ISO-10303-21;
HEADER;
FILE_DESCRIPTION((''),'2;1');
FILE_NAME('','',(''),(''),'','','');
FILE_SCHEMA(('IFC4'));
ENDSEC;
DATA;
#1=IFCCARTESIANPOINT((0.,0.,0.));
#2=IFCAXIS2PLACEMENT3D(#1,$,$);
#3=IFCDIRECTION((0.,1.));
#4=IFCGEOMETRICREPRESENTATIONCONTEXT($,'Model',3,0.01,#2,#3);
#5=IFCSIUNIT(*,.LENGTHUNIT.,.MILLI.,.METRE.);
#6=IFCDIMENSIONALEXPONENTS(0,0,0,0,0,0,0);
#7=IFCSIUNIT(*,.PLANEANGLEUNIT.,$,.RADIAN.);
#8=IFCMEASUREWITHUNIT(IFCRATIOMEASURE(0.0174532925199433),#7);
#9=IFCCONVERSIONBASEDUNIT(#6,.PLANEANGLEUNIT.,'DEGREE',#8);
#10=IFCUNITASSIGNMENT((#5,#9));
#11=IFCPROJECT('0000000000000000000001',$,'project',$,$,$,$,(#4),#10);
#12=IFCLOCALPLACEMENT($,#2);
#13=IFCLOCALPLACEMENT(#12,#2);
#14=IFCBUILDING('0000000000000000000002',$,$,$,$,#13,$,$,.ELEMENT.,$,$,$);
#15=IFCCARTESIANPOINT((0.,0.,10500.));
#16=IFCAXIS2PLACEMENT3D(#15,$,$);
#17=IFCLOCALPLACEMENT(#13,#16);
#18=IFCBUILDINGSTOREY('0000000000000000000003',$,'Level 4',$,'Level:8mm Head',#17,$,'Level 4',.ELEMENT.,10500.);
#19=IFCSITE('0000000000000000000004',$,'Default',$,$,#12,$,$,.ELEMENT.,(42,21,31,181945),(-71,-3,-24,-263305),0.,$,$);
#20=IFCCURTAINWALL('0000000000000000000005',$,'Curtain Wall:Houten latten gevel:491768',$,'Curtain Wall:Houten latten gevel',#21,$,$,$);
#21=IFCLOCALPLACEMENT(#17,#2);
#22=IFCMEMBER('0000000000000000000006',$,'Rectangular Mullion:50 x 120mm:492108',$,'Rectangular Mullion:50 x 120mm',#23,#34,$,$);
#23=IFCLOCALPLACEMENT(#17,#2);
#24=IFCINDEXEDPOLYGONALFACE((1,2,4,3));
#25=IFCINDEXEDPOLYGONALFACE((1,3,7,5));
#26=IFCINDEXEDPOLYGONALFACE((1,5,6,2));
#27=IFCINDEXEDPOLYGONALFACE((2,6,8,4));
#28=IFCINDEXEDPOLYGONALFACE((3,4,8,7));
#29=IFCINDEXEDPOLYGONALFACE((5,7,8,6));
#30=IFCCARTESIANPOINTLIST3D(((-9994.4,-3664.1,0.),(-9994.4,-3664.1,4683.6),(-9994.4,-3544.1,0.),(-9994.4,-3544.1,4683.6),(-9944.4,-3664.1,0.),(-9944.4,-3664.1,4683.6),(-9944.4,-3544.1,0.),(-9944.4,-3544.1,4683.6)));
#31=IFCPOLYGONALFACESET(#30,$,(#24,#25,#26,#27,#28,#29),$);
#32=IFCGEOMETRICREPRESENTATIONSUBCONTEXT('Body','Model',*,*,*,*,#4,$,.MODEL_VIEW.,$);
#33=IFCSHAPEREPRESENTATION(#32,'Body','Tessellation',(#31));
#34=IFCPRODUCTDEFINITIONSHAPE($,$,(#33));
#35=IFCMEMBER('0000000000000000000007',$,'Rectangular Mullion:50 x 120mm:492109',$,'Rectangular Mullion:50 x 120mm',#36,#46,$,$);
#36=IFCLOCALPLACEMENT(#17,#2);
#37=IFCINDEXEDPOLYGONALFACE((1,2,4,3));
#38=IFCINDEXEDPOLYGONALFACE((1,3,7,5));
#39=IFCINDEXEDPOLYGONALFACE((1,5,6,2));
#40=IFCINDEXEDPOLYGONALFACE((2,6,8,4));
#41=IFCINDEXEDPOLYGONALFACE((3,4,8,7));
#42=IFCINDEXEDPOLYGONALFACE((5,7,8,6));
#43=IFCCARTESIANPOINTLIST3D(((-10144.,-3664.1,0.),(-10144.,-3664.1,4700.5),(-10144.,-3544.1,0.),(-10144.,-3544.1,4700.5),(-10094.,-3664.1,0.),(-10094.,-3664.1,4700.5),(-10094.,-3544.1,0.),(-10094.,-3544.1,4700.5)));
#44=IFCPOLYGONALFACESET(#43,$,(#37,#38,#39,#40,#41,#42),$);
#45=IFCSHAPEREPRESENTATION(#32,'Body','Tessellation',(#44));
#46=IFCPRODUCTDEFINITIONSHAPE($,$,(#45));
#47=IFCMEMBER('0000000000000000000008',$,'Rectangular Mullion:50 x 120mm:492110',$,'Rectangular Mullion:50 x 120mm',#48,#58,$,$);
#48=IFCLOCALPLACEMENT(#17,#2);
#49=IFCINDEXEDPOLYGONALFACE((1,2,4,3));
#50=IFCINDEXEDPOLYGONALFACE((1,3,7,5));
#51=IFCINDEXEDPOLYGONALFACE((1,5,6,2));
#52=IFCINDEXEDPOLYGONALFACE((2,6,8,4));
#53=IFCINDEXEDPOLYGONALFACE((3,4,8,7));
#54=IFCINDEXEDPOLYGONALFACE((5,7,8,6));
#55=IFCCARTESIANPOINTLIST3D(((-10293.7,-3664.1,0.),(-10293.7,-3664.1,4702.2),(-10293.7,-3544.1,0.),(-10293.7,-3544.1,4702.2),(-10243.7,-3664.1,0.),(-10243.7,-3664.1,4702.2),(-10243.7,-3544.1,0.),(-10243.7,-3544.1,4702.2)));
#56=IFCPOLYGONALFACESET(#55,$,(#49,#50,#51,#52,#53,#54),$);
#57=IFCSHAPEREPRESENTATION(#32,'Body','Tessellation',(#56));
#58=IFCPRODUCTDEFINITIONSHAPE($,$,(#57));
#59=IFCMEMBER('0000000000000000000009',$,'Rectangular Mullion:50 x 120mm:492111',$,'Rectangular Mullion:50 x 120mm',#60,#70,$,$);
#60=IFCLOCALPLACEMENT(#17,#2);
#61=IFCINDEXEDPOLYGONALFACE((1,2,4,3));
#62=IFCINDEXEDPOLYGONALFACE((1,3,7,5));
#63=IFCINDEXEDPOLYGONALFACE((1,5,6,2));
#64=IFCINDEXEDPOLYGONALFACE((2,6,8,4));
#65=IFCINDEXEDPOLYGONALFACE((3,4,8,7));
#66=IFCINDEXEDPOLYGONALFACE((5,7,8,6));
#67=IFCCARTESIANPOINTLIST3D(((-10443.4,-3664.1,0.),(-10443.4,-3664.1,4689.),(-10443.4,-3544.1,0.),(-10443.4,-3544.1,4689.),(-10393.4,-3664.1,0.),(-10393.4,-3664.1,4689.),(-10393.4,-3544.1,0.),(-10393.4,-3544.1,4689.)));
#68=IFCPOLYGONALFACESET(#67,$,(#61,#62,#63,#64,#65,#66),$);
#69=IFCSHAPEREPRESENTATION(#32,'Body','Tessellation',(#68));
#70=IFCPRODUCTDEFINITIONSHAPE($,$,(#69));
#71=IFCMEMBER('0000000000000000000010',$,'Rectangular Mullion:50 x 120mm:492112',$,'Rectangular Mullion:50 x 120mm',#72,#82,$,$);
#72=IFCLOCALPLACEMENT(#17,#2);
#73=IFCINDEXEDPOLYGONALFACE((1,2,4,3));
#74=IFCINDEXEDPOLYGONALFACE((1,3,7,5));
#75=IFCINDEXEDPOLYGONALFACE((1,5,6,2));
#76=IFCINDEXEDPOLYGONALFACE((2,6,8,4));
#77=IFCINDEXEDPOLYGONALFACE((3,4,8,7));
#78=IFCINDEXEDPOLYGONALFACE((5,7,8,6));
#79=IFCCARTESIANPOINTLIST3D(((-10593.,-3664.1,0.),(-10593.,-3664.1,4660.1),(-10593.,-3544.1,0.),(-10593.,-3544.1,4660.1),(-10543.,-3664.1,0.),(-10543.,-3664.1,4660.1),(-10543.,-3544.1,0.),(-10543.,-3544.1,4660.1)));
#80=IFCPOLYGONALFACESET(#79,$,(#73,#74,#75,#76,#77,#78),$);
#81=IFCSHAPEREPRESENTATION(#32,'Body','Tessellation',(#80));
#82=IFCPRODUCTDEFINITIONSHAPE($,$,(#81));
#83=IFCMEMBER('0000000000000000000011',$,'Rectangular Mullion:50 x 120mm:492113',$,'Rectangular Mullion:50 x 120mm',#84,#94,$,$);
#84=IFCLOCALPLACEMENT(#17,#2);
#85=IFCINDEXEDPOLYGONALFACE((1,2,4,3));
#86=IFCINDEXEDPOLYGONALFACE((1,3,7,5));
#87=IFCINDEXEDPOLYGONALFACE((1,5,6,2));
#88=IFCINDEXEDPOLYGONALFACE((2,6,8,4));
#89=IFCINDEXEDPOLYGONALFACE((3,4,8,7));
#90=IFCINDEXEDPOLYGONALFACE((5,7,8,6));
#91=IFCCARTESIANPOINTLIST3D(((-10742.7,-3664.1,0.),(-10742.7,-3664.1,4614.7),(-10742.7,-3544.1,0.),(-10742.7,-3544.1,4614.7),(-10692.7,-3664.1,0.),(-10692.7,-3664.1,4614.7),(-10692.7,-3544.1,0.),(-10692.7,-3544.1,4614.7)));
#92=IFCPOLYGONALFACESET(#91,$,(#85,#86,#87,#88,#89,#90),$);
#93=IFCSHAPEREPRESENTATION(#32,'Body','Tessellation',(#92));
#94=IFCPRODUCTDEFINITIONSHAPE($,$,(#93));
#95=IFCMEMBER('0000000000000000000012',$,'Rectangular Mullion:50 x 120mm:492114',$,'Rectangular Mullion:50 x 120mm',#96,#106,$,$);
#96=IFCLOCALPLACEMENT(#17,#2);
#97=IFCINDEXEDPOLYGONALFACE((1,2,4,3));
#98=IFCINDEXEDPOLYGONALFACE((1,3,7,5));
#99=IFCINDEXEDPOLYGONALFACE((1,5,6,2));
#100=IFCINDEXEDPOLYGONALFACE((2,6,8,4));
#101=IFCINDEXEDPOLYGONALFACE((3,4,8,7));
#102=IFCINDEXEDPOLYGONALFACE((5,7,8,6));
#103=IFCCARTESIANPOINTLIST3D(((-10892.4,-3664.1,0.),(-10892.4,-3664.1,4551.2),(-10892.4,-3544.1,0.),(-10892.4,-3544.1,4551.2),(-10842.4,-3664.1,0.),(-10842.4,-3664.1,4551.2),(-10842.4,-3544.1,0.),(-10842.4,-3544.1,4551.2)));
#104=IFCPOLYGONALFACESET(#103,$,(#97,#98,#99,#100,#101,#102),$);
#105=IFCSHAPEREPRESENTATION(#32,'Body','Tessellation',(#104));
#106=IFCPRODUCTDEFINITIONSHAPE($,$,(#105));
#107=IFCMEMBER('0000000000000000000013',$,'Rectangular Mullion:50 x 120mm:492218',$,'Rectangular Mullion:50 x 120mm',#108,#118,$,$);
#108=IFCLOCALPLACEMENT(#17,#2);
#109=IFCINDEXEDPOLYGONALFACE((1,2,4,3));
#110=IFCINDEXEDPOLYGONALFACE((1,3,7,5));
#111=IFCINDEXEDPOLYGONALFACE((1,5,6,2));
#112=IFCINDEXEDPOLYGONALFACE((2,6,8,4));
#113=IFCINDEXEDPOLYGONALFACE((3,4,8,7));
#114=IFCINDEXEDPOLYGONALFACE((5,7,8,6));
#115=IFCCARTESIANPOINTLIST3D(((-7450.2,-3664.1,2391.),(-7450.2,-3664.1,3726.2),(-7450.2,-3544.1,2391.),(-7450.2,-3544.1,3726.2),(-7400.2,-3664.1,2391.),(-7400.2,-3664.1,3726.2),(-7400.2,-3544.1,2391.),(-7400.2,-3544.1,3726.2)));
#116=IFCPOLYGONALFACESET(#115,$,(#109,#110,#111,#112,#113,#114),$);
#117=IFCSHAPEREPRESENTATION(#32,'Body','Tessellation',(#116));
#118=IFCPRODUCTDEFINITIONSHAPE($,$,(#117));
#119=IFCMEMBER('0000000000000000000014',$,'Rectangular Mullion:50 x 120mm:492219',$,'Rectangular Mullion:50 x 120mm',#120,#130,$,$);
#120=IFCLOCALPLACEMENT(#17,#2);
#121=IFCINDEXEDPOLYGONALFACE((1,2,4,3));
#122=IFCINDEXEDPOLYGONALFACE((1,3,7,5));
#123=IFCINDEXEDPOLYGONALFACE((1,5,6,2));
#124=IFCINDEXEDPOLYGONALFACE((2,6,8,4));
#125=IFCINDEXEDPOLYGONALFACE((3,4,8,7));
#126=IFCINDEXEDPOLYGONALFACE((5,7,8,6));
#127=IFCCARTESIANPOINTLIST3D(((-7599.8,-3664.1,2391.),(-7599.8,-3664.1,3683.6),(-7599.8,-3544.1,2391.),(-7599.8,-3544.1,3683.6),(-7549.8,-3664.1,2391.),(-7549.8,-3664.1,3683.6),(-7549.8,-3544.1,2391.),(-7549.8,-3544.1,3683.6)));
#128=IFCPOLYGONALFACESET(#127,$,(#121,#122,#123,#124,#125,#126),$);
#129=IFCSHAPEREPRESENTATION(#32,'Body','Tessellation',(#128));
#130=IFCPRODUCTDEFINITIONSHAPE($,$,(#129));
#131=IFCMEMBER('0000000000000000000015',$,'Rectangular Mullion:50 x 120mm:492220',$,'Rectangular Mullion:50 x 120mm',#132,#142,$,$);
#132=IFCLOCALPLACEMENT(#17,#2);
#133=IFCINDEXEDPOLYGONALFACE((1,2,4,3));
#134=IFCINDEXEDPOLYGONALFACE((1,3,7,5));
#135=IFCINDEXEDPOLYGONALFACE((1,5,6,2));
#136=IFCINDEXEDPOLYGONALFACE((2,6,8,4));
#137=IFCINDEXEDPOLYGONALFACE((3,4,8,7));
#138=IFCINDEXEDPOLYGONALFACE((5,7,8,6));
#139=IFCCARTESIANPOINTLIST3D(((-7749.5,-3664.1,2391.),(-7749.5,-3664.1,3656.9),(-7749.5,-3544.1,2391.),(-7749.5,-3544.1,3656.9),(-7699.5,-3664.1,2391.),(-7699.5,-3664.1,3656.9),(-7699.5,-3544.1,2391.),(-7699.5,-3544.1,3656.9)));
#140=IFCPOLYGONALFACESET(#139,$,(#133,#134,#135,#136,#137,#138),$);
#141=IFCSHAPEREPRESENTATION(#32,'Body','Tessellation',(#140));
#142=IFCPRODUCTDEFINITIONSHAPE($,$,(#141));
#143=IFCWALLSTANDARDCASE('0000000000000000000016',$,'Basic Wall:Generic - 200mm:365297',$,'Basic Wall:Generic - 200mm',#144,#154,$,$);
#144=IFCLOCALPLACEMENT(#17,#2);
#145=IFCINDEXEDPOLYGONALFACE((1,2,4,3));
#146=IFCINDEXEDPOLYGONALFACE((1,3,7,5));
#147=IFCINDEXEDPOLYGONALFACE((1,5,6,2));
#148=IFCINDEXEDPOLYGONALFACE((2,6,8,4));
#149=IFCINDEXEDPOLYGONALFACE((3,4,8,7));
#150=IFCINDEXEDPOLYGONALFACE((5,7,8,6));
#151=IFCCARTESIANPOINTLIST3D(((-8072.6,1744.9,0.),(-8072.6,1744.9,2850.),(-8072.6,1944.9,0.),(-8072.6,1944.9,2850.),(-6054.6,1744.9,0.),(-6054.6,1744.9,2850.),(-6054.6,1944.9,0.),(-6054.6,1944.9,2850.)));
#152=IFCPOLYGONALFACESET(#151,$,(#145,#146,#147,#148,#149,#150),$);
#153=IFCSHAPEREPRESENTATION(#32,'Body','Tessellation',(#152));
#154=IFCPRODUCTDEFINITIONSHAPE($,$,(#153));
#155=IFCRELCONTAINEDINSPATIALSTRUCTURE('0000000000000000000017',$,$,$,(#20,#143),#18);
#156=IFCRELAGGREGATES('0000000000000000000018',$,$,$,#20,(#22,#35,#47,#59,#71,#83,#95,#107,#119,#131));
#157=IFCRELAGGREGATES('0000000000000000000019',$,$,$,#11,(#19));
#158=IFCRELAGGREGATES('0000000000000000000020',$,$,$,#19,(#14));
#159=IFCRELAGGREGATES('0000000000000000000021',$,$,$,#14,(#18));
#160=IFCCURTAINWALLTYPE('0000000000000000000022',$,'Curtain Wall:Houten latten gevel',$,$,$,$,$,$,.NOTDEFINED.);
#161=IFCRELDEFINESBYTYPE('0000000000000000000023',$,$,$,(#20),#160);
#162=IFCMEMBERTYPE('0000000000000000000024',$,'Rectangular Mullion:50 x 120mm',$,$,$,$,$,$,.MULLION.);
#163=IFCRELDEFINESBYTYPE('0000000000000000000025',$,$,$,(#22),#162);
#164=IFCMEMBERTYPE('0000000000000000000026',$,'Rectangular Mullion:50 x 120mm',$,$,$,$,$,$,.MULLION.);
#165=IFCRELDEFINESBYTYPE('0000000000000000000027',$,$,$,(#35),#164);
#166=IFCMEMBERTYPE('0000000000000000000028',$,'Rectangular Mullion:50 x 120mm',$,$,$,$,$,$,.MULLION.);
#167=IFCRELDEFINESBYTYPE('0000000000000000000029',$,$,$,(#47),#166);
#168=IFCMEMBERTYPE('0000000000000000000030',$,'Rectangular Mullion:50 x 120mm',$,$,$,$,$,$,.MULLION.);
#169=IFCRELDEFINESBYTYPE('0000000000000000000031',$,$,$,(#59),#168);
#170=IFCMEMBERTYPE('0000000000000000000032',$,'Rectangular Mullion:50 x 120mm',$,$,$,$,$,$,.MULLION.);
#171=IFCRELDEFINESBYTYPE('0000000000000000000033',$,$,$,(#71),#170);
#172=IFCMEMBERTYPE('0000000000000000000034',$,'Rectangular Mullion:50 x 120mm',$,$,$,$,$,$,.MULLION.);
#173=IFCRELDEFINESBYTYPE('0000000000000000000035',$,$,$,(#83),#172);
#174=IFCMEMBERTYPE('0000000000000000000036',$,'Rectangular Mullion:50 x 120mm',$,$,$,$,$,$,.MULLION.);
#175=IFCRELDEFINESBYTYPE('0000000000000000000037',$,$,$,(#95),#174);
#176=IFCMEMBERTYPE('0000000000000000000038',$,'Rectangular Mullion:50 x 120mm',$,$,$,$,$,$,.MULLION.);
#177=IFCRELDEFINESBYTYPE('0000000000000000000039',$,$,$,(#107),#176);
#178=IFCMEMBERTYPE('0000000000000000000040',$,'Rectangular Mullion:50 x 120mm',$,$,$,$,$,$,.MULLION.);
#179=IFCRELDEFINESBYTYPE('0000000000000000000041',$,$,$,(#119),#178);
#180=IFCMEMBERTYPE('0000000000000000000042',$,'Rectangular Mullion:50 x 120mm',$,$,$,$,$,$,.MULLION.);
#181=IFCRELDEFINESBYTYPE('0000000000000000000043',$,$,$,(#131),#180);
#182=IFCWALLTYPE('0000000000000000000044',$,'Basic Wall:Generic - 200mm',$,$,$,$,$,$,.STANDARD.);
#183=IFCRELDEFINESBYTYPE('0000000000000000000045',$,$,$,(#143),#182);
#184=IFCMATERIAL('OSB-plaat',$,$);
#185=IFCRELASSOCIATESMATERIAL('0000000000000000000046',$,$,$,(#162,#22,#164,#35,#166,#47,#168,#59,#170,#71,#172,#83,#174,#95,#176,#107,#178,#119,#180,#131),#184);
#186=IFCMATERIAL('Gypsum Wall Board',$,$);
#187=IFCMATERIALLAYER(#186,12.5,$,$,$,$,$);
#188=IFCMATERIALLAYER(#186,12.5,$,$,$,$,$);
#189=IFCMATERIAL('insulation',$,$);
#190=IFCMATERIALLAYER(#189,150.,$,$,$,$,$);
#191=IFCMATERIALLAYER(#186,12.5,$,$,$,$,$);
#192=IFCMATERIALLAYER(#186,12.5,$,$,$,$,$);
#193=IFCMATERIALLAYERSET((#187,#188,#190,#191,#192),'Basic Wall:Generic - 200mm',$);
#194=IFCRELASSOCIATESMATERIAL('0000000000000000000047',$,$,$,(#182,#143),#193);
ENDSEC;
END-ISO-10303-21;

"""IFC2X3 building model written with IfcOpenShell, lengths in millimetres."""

from ifc_helpers import new_model, entity, si_unit, converted_unit, direction, frame, frame_2d, origin, origin_2d_with_axis, place, context, subcontext, project, spatial, rectangle, extrude, source, transform, mapped, material, layer, layer_set, layer_usage, type_object, type_shapes, element, aggregate, save


model = new_model("IFC2X3")

# Units and contexts
model_context = context("Model", 3, precision=0.01, world=origin(), true_north=direction((0.0, 1.0)))
body_context = subcontext(model_context, "Body", "Model", "MODEL_VIEW")
ifc_project = project(units=[si_unit("LENGTHUNIT", "METRE", prefix="MILLI"), converted_unit("PLANEANGLEUNIT", "DEGREE", entity("IfcRatioMeasure", 0.0174532925199433), si_unit("PLANEANGLEUNIT", "RADIAN"), dimensions=[0, 0, 0, 0, 0, 0, 0])], contexts=[model_context])

# Site, building, storey
site_placement = place(None, frame((0.0, 0.0, 0.0)))
site = spatial("IfcSite", under=ifc_project, at=site_placement, Name="Default", CompositionType="ELEMENT", RefLatitude=(42, 21, 31, 181945), RefLongitude=(-71, -3, -24, -263305), RefElevation=0.0)
building_placement = place(site_placement, origin())
building = spatial("IfcBuilding", under=site, at=building_placement, CompositionType="ELEMENT")
storey_placement = place(building_placement, frame((0.0, 0.0, 10500.0)))
storey = spatial("IfcBuildingStorey", under=building, at=storey_placement, Name="Level 4", ObjectType="Level:8mm Head", LongName="Level 4", CompositionType="ELEMENT", Elevation=10500.0)

# Curtain wall, members
curtain_wall_type_1 = type_object("IfcCurtainWallType", Name="Curtain Wall:Houten latten gevel", PredefinedType="NOTDEFINED")
curtain_wall_1_placement = place(storey_placement, frame((0.0, 0.0, -10500.0)))
curtain_wall_1 = element("IfcCurtainWall", 1, at=curtain_wall_1_placement, inside=storey, type_object=curtain_wall_type_1, Name="Curtain Wall:Houten latten gevel:491768", ObjectType="Curtain Wall:Houten latten gevel")
ifc_material_1 = material(Name="OSB-plaat")
placement = place(building_placement, frame((0.0, 0.0, 7500.0)))
member_type_1 = type_object("IfcMemberType", Name="Rectangular Mullion:50 x 120mm", PredefinedType="MULLION", material=ifc_material_1)
shared_shape_1 = source(origin(), body_context, "Body", "SweptSolid", [
    extrude(rectangle(XDim=120.0, YDim=50.0, at=origin_2d_with_axis()), frame((0.0, 0.0, -4683.6), z_axis=(0.0, 0.0, 1.0), x_axis=(0.0, -1.0, 0.0)), (0.0, 0.0, 1.0), 4683.6),
])
type_shapes(member_type_1, [shared_shape_1])
member_1_placement = place(placement, frame((-9969.4, -3604.1, 3000.0), z_axis=(0.0, 0.0, -1.0), x_axis=(-1.0, 0.0, 0.0)))
member_1 = element("IfcMember", 2, at=member_1_placement, type_object=member_type_1, material=ifc_material_1, Name="Rectangular Mullion:50 x 120mm:492108", ObjectType="Rectangular Mullion:50 x 120mm", context=body_context, shape_type="MappedRepresentation", body=[
    mapped(shared_shape_1, transform((0.0, 0.0, 0.0), scale=1.0)),
])
member_type_2 = type_object("IfcMemberType", Name="Rectangular Mullion:50 x 120mm", PredefinedType="MULLION", material=ifc_material_1)
shared_shape_2 = source(origin(), body_context, "Body", "SweptSolid", [
    extrude(rectangle(XDim=120.0, YDim=50.0, at=origin_2d_with_axis()), frame((0.0, 0.0, -4700.5), z_axis=(0.0, 0.0, 1.0), x_axis=(0.0, -1.0, 0.0)), (0.0, 0.0, 1.0), 4700.5),
])
type_shapes(member_type_2, [shared_shape_2])
member_2_placement = place(placement, frame((-10119.0, -3604.1, 3000.0), z_axis=(0.0, 0.0, -1.0), x_axis=(-1.0, 0.0, 0.0)))
member_2 = element("IfcMember", 3, at=member_2_placement, type_object=member_type_2, material=ifc_material_1, Name="Rectangular Mullion:50 x 120mm:492109", ObjectType="Rectangular Mullion:50 x 120mm", context=body_context, shape_type="MappedRepresentation", body=[
    mapped(shared_shape_2, transform((0.0, 0.0, 0.0), scale=1.0)),
])
member_type_3 = type_object("IfcMemberType", Name="Rectangular Mullion:50 x 120mm", PredefinedType="MULLION", material=ifc_material_1)
shared_shape_3 = source(origin(), body_context, "Body", "SweptSolid", [
    extrude(rectangle(XDim=120.0, YDim=50.0, at=origin_2d_with_axis()), frame((0.0, 0.0, -4702.2), z_axis=(0.0, 0.0, 1.0), x_axis=(0.0, -1.0, 0.0)), (0.0, 0.0, 1.0), 4702.2),
])
type_shapes(member_type_3, [shared_shape_3])
member_3_placement = place(placement, frame((-10268.7, -3604.1, 3000.0), z_axis=(0.0, 0.0, -1.0), x_axis=(-1.0, 0.0, 0.0)))
member_3 = element("IfcMember", 4, at=member_3_placement, type_object=member_type_3, material=ifc_material_1, Name="Rectangular Mullion:50 x 120mm:492110", ObjectType="Rectangular Mullion:50 x 120mm", context=body_context, shape_type="MappedRepresentation", body=[
    mapped(shared_shape_3, transform((0.0, 0.0, 0.0), scale=1.0)),
])
member_type_4 = type_object("IfcMemberType", Name="Rectangular Mullion:50 x 120mm", PredefinedType="MULLION", material=ifc_material_1)
shared_shape_4 = source(origin(), body_context, "Body", "SweptSolid", [
    extrude(rectangle(XDim=120.0, YDim=50.0, at=origin_2d_with_axis()), frame((0.0, 0.0, -4689.0), z_axis=(0.0, 0.0, 1.0), x_axis=(0.0, -1.0, 0.0)), (0.0, 0.0, 1.0), 4689.0),
])
type_shapes(member_type_4, [shared_shape_4])
member_4_placement = place(placement, frame((-10418.4, -3604.1, 3000.0), z_axis=(0.0, 0.0, -1.0), x_axis=(-1.0, 0.0, 0.0)))
member_4 = element("IfcMember", 5, at=member_4_placement, type_object=member_type_4, material=ifc_material_1, Name="Rectangular Mullion:50 x 120mm:492111", ObjectType="Rectangular Mullion:50 x 120mm", context=body_context, shape_type="MappedRepresentation", body=[
    mapped(shared_shape_4, transform((0.0, 0.0, 0.0), scale=1.0)),
])
member_type_5 = type_object("IfcMemberType", Name="Rectangular Mullion:50 x 120mm", PredefinedType="MULLION", material=ifc_material_1)
shared_shape_5 = source(origin(), body_context, "Body", "SweptSolid", [
    extrude(rectangle(XDim=120.0, YDim=50.0, at=origin_2d_with_axis()), frame((0.0, 0.0, -4660.1), z_axis=(0.0, 0.0, 1.0), x_axis=(0.0, -1.0, 0.0)), (0.0, 0.0, 1.0), 4660.1),
])
type_shapes(member_type_5, [shared_shape_5])
member_5_placement = place(placement, frame((-10568.0, -3604.1, 3000.0), z_axis=(0.0, 0.0, -1.0), x_axis=(-1.0, 0.0, 0.0)))
member_5 = element("IfcMember", 6, at=member_5_placement, type_object=member_type_5, material=ifc_material_1, Name="Rectangular Mullion:50 x 120mm:492112", ObjectType="Rectangular Mullion:50 x 120mm", context=body_context, shape_type="MappedRepresentation", body=[
    mapped(shared_shape_5, transform((0.0, 0.0, 0.0), scale=1.0)),
])
member_type_6 = type_object("IfcMemberType", Name="Rectangular Mullion:50 x 120mm", PredefinedType="MULLION", material=ifc_material_1)
shared_shape_6 = source(origin(), body_context, "Body", "SweptSolid", [
    extrude(rectangle(XDim=120.0, YDim=50.0, at=origin_2d_with_axis()), frame((0.0, 0.0, -4614.7), z_axis=(0.0, 0.0, 1.0), x_axis=(0.0, -1.0, 0.0)), (0.0, 0.0, 1.0), 4614.7),
])
type_shapes(member_type_6, [shared_shape_6])
member_6_placement = place(placement, frame((-10717.7, -3604.1, 3000.0), z_axis=(0.0, 0.0, -1.0), x_axis=(-1.0, 0.0, 0.0)))
member_6 = element("IfcMember", 7, at=member_6_placement, type_object=member_type_6, material=ifc_material_1, Name="Rectangular Mullion:50 x 120mm:492113", ObjectType="Rectangular Mullion:50 x 120mm", context=body_context, shape_type="MappedRepresentation", body=[
    mapped(shared_shape_6, transform((0.0, 0.0, 0.0), scale=1.0)),
])
member_type_7 = type_object("IfcMemberType", Name="Rectangular Mullion:50 x 120mm", PredefinedType="MULLION", material=ifc_material_1)
shared_shape_7 = source(origin(), body_context, "Body", "SweptSolid", [
    extrude(rectangle(XDim=120.0, YDim=50.0, at=origin_2d_with_axis()), frame((0.0, 0.0, -4551.2), z_axis=(0.0, 0.0, 1.0), x_axis=(0.0, -1.0, 0.0)), (0.0, 0.0, 1.0), 4551.2),
])
type_shapes(member_type_7, [shared_shape_7])
member_7_placement = place(placement, frame((-10867.4, -3604.1, 3000.0), z_axis=(0.0, 0.0, -1.0), x_axis=(-1.0, 0.0, 0.0)))
member_7 = element("IfcMember", 8, at=member_7_placement, type_object=member_type_7, material=ifc_material_1, Name="Rectangular Mullion:50 x 120mm:492114", ObjectType="Rectangular Mullion:50 x 120mm", context=body_context, shape_type="MappedRepresentation", body=[
    mapped(shared_shape_7, transform((0.0, 0.0, 0.0), scale=1.0)),
])
member_type_8 = type_object("IfcMemberType", Name="Rectangular Mullion:50 x 120mm", PredefinedType="MULLION", material=ifc_material_1)
shared_shape_8 = source(origin(), body_context, "Body", "SweptSolid", [
    extrude(rectangle(XDim=120.0, YDim=50.0, at=origin_2d_with_axis()), frame((0.0, 0.0, -1335.2), z_axis=(0.0, 0.0, 1.0), x_axis=(0.0, -1.0, 0.0)), (0.0, 0.0, 1.0), 1335.2),
])
type_shapes(member_type_8, [shared_shape_8])
member_8_placement = place(placement, frame((-7425.2, -3604.1, 5391.0), z_axis=(0.0, 0.0, -1.0), x_axis=(-1.0, 0.0, 0.0)))
member_8 = element("IfcMember", 9, at=member_8_placement, type_object=member_type_8, material=ifc_material_1, Name="Rectangular Mullion:50 x 120mm:492218", ObjectType="Rectangular Mullion:50 x 120mm", context=body_context, shape_type="MappedRepresentation", body=[
    mapped(shared_shape_8, transform((0.0, 0.0, 0.0), scale=1.0)),
])
member_type_9 = type_object("IfcMemberType", Name="Rectangular Mullion:50 x 120mm", PredefinedType="MULLION", material=ifc_material_1)
shared_shape_9 = source(origin(), body_context, "Body", "SweptSolid", [
    extrude(rectangle(XDim=120.0, YDim=50.0, at=origin_2d_with_axis()), frame((0.0, 0.0, -1292.6), z_axis=(0.0, 0.0, 1.0), x_axis=(0.0, -1.0, 0.0)), (0.0, 0.0, 1.0), 1292.6),
])
type_shapes(member_type_9, [shared_shape_9])
member_9_placement = place(placement, frame((-7574.8, -3604.1, 5391.0), z_axis=(0.0, 0.0, -1.0), x_axis=(-1.0, 0.0, 0.0)))
member_9 = element("IfcMember", 10, at=member_9_placement, type_object=member_type_9, material=ifc_material_1, Name="Rectangular Mullion:50 x 120mm:492219", ObjectType="Rectangular Mullion:50 x 120mm", context=body_context, shape_type="MappedRepresentation", body=[
    mapped(shared_shape_9, transform((0.0, 0.0, 0.0), scale=1.0)),
])
member_type_10 = type_object("IfcMemberType", Name="Rectangular Mullion:50 x 120mm", PredefinedType="MULLION", material=ifc_material_1)
shared_shape_10 = source(origin(), body_context, "Body", "SweptSolid", [
    extrude(rectangle(XDim=120.0, YDim=50.0, at=origin_2d_with_axis()), frame((0.0, 0.0, -1265.9), z_axis=(0.0, 0.0, 1.0), x_axis=(0.0, -1.0, 0.0)), (0.0, 0.0, 1.0), 1265.9),
])
type_shapes(member_type_10, [shared_shape_10])
member_10_placement = place(placement, frame((-7724.5, -3604.1, 5391.0), z_axis=(0.0, 0.0, -1.0), x_axis=(-1.0, 0.0, 0.0)))
member_10 = element("IfcMember", 11, at=member_10_placement, type_object=member_type_10, material=ifc_material_1, Name="Rectangular Mullion:50 x 120mm:492220", ObjectType="Rectangular Mullion:50 x 120mm", context=body_context, shape_type="MappedRepresentation", body=[
    mapped(shared_shape_10, transform((0.0, 0.0, 0.0), scale=1.0)),
])
aggregate(curtain_wall_1, [member_1, member_2, member_3, member_4, member_5, member_6, member_7, member_8, member_9, member_10])

# Wall
ifc_material_2 = material(Name="Gypsum Wall Board")
ifc_layer_1 = layer(ifc_material_2, 12.5)
ifc_layer_2 = layer(ifc_material_2, 12.5)
ifc_material_3 = material(Name="insulation")
ifc_layer_3 = layer(ifc_material_3, 150.0)
ifc_layer_4 = layer(ifc_material_2, 12.5)
ifc_layer_5 = layer(ifc_material_2, 12.5)
ifc_layer_set = layer_set([ifc_layer_1, ifc_layer_2, ifc_layer_3, ifc_layer_4, ifc_layer_5], Name="Basic Wall:Generic - 200mm")
ifc_layer_usage_1 = layer_usage(ifc_layer_set, "AXIS2", "NEGATIVE", 100.0)
wall_type = type_object("IfcWallType", Name="Basic Wall:Generic - 200mm", PredefinedType="STANDARD", material=ifc_layer_set)
wall_1_placement = place(storey_placement, frame((-8072.6, 1844.9, 0.0)))
element("IfcWallStandardCase", 12, at=wall_1_placement, inside=storey, type_object=wall_type, material=ifc_layer_usage_1, Name="Basic Wall:Generic - 200mm:365297", ObjectType="Basic Wall:Generic - 200mm", context=body_context, shape_type="SweptSolid", body=[
    extrude(rectangle(XDim=2018.0, YDim=200.0, at=frame_2d((1009.0, 0.0), x_axis=(-1.0, 0.0))), origin(), (0.0, 0.0, 1.0), 2850.0),
])

save(model, "model.ifc")
